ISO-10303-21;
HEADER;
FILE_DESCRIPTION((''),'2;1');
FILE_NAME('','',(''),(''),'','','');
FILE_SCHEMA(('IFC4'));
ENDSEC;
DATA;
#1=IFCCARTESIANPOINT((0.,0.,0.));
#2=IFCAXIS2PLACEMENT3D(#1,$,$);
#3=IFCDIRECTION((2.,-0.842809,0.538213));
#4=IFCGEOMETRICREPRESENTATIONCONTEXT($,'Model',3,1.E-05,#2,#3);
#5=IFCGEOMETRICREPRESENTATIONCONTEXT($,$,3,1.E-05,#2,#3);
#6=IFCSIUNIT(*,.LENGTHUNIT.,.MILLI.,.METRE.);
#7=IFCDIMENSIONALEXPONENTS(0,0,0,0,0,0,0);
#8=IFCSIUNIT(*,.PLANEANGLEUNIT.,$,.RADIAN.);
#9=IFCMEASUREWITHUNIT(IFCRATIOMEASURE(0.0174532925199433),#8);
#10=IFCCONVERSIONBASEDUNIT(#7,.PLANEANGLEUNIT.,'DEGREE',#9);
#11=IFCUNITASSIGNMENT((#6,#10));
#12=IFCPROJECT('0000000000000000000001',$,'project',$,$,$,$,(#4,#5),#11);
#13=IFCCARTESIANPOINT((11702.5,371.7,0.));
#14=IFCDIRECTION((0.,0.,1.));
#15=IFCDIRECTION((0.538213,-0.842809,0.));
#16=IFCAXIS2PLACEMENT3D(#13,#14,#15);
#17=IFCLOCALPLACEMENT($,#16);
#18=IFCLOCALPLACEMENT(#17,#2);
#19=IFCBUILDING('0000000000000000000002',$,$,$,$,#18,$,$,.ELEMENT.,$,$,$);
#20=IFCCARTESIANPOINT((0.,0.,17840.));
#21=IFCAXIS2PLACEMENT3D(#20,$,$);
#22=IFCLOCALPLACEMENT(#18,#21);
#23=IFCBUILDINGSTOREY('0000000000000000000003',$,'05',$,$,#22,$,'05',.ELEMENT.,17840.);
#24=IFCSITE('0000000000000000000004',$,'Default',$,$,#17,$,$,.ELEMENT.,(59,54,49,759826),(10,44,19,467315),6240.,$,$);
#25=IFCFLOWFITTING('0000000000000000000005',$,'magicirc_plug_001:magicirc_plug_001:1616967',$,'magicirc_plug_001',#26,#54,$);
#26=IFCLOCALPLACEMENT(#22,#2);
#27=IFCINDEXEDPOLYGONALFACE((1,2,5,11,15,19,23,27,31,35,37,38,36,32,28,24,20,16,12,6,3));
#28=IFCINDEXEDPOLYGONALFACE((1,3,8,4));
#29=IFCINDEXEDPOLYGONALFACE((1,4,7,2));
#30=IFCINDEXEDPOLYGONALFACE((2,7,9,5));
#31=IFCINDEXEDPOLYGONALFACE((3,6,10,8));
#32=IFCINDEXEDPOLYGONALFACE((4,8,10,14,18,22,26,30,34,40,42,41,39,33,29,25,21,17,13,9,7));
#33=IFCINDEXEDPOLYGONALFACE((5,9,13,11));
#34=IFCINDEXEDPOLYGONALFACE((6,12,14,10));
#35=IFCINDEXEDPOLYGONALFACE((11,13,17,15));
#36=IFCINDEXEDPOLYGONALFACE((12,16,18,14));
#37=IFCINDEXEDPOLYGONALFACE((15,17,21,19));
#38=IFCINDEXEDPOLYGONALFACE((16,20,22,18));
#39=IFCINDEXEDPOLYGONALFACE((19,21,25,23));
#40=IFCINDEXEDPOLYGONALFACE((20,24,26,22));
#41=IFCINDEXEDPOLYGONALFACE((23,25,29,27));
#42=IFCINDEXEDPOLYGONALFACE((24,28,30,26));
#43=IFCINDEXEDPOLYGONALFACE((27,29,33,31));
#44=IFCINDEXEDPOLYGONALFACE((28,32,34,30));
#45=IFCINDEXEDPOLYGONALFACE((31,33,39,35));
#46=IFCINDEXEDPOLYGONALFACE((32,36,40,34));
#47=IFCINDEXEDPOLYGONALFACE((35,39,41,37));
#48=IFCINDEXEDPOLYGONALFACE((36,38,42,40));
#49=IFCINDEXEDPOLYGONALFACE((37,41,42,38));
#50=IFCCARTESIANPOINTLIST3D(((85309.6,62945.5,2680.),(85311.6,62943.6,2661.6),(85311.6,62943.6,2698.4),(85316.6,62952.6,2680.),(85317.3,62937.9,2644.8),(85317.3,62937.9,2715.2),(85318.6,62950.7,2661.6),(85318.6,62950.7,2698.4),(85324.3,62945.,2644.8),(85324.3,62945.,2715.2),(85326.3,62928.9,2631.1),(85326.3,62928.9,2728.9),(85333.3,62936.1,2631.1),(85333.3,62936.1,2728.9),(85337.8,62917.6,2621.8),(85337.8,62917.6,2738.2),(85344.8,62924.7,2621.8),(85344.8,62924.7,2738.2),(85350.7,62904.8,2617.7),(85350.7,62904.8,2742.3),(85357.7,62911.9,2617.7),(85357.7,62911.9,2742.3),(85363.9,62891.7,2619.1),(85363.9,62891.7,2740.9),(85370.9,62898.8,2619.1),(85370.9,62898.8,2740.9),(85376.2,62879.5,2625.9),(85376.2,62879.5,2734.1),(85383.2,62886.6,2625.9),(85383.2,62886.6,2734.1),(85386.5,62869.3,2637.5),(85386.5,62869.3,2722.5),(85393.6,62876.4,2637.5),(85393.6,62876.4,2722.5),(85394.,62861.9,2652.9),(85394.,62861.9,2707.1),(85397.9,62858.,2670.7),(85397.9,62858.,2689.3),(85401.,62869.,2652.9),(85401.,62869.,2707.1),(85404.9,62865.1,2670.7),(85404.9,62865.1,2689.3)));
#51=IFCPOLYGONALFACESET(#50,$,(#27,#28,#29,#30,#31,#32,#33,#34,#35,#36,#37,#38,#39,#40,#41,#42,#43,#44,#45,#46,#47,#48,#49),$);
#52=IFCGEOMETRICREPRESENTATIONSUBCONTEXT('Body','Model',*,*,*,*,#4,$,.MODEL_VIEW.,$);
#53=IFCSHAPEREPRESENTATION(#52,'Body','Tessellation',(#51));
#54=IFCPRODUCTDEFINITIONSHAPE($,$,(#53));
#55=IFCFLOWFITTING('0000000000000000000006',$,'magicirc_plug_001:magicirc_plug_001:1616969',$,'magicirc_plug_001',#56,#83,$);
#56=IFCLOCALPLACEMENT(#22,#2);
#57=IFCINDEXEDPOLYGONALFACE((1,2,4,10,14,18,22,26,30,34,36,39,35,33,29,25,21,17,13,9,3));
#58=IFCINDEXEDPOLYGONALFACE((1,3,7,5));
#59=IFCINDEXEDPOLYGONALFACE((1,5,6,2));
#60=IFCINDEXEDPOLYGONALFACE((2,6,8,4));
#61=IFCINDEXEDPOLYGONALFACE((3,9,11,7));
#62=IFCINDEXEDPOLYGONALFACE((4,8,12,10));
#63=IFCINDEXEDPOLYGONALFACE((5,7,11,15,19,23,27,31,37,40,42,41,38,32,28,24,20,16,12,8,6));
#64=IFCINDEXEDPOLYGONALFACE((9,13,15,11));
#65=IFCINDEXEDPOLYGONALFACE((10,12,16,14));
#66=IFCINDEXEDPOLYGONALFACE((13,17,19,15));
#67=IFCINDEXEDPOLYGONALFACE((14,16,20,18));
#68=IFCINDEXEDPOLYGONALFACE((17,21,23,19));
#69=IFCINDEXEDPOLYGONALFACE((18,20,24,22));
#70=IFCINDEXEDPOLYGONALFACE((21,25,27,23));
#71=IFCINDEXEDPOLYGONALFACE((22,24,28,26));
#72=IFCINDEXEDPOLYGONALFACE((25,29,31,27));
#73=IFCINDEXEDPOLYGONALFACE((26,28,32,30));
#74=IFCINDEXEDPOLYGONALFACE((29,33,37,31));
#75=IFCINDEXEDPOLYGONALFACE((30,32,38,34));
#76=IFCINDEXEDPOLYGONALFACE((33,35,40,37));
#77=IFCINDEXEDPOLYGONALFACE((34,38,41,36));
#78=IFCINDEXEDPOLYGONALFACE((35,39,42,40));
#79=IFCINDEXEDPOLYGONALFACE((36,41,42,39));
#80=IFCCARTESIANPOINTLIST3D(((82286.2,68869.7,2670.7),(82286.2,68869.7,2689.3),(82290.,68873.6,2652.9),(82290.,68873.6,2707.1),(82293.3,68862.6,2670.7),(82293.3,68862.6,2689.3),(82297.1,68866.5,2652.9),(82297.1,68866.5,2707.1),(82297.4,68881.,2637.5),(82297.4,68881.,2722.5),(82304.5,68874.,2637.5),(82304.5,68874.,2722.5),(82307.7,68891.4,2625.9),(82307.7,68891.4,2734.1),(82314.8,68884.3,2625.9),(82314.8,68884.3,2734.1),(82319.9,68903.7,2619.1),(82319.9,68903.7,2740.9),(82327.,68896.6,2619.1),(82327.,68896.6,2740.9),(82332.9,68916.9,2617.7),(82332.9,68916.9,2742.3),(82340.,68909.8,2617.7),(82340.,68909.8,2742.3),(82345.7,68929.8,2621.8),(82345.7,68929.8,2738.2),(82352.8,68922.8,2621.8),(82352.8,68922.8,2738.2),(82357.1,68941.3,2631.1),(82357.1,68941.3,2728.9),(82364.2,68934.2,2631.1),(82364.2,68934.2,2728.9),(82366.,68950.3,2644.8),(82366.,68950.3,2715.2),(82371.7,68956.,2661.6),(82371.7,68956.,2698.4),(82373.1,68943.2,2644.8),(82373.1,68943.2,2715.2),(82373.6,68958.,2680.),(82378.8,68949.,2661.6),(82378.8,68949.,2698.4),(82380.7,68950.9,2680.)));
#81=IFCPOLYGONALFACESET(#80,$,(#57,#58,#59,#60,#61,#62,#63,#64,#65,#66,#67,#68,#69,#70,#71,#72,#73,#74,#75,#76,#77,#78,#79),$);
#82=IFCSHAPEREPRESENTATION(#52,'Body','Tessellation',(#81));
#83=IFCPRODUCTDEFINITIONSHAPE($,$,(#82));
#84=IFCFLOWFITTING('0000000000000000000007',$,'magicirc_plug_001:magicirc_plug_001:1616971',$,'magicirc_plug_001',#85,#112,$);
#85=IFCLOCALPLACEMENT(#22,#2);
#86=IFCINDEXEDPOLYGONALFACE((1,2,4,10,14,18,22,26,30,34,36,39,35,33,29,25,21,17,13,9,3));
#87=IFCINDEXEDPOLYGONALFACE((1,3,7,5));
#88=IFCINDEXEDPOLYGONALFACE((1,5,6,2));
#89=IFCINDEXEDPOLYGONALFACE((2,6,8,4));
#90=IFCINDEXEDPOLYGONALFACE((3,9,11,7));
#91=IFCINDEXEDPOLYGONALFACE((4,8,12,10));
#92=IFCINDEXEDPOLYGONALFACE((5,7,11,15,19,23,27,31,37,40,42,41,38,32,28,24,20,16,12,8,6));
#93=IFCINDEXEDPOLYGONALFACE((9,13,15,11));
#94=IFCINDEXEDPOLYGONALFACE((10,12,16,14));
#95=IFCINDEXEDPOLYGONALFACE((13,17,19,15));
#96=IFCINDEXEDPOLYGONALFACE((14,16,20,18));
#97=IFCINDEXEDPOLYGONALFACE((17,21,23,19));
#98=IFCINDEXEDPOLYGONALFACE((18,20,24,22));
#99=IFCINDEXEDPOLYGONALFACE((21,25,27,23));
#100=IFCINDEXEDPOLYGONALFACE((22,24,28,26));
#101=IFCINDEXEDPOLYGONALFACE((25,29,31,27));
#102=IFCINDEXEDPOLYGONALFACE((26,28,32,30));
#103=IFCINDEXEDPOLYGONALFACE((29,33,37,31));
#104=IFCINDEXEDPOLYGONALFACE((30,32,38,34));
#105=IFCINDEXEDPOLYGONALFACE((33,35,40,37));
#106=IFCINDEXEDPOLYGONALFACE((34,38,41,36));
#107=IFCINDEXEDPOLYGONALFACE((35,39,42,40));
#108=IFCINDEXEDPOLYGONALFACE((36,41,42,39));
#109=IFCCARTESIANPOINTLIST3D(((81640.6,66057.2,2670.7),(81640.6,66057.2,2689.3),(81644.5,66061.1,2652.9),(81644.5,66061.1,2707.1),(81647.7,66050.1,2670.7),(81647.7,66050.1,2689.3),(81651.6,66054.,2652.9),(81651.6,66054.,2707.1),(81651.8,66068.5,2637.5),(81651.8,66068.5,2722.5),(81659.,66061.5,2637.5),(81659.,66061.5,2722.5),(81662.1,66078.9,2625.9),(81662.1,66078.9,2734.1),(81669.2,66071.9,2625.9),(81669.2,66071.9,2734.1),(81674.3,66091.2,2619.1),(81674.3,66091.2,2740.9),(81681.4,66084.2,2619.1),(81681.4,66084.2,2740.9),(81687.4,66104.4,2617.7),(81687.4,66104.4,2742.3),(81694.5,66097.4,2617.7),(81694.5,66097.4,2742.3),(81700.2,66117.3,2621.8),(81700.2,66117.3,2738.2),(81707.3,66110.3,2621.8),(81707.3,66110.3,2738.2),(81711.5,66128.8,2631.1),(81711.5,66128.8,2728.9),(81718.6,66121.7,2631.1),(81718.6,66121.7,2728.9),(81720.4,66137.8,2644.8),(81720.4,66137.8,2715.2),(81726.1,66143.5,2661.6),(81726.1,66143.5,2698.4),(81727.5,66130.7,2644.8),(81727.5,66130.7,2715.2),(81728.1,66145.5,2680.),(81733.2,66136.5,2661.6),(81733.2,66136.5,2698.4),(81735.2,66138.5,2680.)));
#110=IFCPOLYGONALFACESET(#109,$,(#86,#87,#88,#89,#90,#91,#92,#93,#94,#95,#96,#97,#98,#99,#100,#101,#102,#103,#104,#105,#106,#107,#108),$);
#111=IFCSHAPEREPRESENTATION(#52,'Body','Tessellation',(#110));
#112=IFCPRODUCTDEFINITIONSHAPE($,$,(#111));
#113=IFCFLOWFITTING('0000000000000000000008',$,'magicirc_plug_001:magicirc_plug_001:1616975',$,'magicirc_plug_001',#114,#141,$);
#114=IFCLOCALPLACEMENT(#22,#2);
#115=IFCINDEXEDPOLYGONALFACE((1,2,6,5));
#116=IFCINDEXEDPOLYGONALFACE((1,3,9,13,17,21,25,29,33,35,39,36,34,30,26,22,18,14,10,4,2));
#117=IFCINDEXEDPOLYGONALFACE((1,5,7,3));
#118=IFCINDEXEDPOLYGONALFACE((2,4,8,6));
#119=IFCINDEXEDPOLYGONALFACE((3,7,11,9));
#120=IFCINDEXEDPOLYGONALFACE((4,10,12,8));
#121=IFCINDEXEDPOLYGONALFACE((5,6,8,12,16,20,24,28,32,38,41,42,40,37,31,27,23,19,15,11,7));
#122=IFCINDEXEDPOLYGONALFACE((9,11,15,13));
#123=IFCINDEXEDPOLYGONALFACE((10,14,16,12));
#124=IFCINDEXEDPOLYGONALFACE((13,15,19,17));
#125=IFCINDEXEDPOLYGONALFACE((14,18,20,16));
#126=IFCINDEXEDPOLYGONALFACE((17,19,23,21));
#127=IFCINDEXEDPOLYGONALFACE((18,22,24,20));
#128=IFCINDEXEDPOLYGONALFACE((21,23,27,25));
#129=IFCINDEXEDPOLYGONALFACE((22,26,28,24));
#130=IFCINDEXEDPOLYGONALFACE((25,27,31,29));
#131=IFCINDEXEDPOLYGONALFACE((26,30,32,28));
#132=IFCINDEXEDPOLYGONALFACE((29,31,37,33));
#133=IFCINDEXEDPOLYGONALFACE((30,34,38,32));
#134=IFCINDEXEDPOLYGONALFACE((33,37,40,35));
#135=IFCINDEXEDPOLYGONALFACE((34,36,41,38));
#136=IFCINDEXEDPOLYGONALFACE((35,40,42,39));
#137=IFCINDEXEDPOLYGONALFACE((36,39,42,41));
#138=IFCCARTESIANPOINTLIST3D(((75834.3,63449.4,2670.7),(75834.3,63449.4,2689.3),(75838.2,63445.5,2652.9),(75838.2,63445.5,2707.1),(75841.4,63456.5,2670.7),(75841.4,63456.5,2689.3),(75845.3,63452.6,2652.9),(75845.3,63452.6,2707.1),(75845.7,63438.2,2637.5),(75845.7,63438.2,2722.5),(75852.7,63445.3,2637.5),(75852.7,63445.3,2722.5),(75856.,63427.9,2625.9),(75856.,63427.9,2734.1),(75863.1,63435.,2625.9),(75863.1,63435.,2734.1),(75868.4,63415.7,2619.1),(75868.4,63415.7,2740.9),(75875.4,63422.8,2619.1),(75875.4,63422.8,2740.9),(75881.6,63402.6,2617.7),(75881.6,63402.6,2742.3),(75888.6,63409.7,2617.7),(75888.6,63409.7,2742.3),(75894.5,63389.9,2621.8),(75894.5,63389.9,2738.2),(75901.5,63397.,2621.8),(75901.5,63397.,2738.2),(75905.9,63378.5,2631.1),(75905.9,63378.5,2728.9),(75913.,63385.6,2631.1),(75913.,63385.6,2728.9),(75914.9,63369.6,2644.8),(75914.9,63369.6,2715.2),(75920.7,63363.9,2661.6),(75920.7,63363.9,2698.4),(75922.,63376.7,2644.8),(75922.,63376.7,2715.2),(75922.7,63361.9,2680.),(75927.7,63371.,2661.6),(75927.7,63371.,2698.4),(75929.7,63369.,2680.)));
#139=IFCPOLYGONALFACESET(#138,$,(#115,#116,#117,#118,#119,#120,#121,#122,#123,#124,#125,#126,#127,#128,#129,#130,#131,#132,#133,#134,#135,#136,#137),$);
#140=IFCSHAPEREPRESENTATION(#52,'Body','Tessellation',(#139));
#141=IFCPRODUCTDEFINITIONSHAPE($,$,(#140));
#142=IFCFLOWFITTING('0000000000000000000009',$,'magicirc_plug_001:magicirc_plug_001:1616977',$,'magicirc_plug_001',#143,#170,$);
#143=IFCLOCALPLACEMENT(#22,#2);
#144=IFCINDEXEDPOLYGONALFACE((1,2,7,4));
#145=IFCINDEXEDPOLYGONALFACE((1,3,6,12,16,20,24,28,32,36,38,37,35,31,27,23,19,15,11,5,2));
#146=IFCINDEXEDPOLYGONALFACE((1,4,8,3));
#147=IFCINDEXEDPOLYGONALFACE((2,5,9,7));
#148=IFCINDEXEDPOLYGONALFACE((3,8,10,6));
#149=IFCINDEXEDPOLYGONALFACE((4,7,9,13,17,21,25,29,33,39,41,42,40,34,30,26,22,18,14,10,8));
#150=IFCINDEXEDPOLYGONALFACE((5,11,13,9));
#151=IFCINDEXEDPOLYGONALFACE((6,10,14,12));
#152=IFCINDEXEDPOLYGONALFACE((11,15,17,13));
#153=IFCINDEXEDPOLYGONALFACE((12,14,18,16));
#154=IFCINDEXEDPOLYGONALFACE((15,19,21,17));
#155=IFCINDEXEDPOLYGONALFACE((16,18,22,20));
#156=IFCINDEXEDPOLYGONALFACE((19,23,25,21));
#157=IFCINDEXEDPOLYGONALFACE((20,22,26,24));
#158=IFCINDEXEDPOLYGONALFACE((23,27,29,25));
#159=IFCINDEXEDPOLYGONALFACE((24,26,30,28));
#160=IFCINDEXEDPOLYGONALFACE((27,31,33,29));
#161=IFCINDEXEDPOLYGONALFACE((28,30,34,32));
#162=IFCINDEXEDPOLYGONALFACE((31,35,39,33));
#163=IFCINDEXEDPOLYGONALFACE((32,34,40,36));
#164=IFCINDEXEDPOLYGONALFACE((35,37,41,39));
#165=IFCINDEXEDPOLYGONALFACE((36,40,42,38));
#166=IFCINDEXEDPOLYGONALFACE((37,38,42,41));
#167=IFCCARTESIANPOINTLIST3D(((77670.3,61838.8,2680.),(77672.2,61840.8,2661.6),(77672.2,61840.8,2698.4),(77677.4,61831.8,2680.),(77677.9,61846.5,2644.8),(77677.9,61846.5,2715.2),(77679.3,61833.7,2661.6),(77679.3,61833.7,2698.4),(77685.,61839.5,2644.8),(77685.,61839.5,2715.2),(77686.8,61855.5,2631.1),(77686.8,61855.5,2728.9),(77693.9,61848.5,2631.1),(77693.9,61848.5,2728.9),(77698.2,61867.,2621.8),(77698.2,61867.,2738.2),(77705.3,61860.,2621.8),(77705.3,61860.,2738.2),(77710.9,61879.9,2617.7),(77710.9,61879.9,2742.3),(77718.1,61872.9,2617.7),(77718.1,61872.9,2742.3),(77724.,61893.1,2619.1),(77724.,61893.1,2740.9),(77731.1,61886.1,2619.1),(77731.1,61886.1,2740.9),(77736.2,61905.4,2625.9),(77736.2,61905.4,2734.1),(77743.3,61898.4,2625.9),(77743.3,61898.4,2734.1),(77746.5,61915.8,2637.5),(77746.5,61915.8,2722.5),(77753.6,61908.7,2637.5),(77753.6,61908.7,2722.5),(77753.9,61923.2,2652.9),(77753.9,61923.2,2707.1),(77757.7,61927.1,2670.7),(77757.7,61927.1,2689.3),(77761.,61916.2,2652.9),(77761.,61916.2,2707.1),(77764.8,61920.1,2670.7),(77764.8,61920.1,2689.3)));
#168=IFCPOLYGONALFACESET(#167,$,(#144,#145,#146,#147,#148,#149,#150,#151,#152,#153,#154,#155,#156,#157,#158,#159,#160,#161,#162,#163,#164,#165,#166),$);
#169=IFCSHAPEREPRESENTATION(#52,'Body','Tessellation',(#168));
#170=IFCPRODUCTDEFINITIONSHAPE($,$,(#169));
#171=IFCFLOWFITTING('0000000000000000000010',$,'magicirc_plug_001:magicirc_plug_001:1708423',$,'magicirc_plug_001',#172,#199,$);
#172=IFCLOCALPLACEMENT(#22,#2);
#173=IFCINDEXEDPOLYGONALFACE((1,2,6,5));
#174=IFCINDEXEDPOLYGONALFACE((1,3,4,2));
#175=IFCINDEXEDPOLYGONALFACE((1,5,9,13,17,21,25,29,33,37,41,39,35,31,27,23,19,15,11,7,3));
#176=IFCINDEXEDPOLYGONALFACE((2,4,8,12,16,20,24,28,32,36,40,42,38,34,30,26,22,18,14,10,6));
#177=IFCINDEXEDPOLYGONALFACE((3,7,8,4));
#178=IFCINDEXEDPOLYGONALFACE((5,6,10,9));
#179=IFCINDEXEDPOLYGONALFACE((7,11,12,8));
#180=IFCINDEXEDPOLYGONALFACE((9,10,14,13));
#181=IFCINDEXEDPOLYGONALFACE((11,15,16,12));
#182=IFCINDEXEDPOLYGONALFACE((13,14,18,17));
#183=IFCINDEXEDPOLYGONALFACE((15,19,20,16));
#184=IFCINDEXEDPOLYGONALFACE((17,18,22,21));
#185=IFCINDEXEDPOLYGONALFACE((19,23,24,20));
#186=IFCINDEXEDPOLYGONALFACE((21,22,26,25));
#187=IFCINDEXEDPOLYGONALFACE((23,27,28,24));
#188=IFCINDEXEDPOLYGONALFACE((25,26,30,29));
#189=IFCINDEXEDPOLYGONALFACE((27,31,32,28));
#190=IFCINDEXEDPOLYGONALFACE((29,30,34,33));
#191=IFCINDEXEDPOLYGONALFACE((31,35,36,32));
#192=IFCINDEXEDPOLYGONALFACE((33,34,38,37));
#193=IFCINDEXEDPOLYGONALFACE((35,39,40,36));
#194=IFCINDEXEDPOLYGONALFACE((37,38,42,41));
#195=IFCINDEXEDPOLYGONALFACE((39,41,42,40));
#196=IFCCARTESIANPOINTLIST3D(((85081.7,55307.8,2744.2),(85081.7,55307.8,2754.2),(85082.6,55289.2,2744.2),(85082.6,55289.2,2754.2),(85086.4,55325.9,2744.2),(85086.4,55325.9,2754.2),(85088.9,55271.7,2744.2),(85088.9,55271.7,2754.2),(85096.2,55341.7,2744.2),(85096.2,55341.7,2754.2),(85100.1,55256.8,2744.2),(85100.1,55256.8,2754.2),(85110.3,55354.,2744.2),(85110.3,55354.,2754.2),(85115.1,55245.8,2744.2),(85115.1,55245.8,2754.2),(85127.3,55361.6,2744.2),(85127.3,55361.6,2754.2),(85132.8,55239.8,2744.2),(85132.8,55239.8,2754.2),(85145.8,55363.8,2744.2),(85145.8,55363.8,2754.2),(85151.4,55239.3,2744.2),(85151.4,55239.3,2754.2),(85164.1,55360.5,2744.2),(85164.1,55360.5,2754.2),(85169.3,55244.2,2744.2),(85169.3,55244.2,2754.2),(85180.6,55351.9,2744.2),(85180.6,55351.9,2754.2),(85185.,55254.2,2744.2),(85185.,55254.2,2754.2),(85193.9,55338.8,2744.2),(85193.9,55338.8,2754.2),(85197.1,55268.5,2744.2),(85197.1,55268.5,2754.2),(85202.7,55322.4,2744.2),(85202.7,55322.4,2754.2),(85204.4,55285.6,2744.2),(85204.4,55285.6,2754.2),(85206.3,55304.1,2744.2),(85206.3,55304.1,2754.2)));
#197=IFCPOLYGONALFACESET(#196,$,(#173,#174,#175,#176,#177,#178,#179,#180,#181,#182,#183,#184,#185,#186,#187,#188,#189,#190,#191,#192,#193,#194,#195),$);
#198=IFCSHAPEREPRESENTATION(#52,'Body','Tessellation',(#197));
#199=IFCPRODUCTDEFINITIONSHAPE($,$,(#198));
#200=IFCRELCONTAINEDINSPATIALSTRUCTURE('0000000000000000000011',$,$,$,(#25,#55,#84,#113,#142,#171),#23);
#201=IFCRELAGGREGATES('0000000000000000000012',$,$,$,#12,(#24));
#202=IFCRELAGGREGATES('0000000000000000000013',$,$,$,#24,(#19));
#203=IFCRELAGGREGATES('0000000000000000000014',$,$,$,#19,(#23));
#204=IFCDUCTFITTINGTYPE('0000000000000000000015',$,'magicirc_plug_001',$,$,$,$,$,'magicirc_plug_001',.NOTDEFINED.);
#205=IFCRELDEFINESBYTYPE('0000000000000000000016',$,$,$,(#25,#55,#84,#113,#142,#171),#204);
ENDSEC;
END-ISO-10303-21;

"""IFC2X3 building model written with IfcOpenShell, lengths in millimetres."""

from ifc_helpers import new_model, entity, si_unit, converted_unit, direction, frame, frame_2d, origin, place, context, subcontext, project, spatial, circle, extrude, source, transform, mapped, type_object, type_shapes, element, save


model = new_model("IFC2X3")

# Units and contexts
model_context = context("Model", 3, precision=1e-05, world=origin(), true_north=direction((2.0, -0.842809, 0.538213)))
context_of_model = context(None, 3, precision=1e-05, world=origin(), true_north=direction((2.0, -0.842809, 0.538213)))
body_context = subcontext(model_context, "Body", "Model", "MODEL_VIEW")
ifc_project = project(units=[si_unit("LENGTHUNIT", "METRE", prefix="MILLI"), converted_unit("PLANEANGLEUNIT", "DEGREE", entity("IfcRatioMeasure", 0.0174532925199433), si_unit("PLANEANGLEUNIT", "RADIAN"), dimensions=[0, 0, 0, 0, 0, 0, 0])], contexts=[model_context, context_of_model])

# Site, building, storey
site_placement = place(None, frame((11702.5, 371.7, 0.0), z_axis=(0.0, 0.0, 1.0), x_axis=(0.538213, -0.842809, 0.0)))
site = spatial("IfcSite", under=ifc_project, at=site_placement, Name="Default", CompositionType="ELEMENT", RefLatitude=(59, 54, 49, 759826), RefLongitude=(10, 44, 19, 467315), RefElevation=6240.0)
building_placement = place(site_placement, origin())
building = spatial("IfcBuilding", under=site, at=building_placement, CompositionType="ELEMENT")
storey_placement = place(building_placement, frame((0.0, 0.0, 17840.0)))
storey = spatial("IfcBuildingStorey", under=building, at=storey_placement, Name="05", LongName="05", CompositionType="ELEMENT", Elevation=17840.0)

# Flow fittings
duct_fitting_type_1 = type_object("IfcDuctFittingType", Name="magicirc_plug_001", ElementType="magicirc_plug_001", PredefinedType="NOTDEFINED")
shared_shape_1 = source(origin(), body_context, "Body", "SweptSolid", [
    extrude(circle(Radius=62.5, at=frame_2d((0.0, 0.0), x_axis=(1.0, 0.0))), frame((0.0, 0.0, 0.0), z_axis=(1.0, 0.0, 0.0), x_axis=(0.0, 1.0, 0.0)), (0.0, 0.0, 1.0), 10.0),
])
type_shapes(duct_fitting_type_1, [shared_shape_1])
for number, where, z_axis, x_axis, name in (
    (1, (85354.0, 62901.5, 2680.0), (0.0, 0.0, 1.0), (0.703669, 0.710528, 0.0), "magicirc_plug_001:magicirc_plug_001:1616967"),
    (2, (82329.6, 68913.6, 2680.0), (0.0, 0.0, 1.0), (0.710528, -0.703669, 0.0), "magicirc_plug_001:magicirc_plug_001:1616969"),
    (3, (81684.1, 66101.1, 2680.0), (0.0, 0.0, 1.0), (0.710528, -0.703669, 0.0), "magicirc_plug_001:magicirc_plug_001:1616971"),
    (4, (75885.3, 63413.0, 2680.0), (0.0, 0.0, 1.0), (-0.703669, -0.710528, 0.0), "magicirc_plug_001:magicirc_plug_001:1616975"),
    (5, (77721.3, 61876.2, 2680.0), (0.0, 0.0, 1.0), (-0.710528, 0.703669, 0.0), "magicirc_plug_001:magicirc_plug_001:1616977"),
    (6, (85143.9, 55301.3, 2744.2), (0.71249, -0.701682, 0.0), (0.0, 0.0, 1.0), "magicirc_plug_001:magicirc_plug_001:1708423"),
):
    element("IfcFlowFitting", number, at=place(storey_placement, frame(where, z_axis=z_axis, x_axis=x_axis)), inside=storey, type_object=duct_fitting_type_1, Name=name, ObjectType="magicirc_plug_001", context=body_context, shape_type="MappedRepresentation", body=[
        mapped(shared_shape_1, transform((0.0, 0.0, 0.0), scale=1.0)),
    ])

save(model, "model.ifc")
